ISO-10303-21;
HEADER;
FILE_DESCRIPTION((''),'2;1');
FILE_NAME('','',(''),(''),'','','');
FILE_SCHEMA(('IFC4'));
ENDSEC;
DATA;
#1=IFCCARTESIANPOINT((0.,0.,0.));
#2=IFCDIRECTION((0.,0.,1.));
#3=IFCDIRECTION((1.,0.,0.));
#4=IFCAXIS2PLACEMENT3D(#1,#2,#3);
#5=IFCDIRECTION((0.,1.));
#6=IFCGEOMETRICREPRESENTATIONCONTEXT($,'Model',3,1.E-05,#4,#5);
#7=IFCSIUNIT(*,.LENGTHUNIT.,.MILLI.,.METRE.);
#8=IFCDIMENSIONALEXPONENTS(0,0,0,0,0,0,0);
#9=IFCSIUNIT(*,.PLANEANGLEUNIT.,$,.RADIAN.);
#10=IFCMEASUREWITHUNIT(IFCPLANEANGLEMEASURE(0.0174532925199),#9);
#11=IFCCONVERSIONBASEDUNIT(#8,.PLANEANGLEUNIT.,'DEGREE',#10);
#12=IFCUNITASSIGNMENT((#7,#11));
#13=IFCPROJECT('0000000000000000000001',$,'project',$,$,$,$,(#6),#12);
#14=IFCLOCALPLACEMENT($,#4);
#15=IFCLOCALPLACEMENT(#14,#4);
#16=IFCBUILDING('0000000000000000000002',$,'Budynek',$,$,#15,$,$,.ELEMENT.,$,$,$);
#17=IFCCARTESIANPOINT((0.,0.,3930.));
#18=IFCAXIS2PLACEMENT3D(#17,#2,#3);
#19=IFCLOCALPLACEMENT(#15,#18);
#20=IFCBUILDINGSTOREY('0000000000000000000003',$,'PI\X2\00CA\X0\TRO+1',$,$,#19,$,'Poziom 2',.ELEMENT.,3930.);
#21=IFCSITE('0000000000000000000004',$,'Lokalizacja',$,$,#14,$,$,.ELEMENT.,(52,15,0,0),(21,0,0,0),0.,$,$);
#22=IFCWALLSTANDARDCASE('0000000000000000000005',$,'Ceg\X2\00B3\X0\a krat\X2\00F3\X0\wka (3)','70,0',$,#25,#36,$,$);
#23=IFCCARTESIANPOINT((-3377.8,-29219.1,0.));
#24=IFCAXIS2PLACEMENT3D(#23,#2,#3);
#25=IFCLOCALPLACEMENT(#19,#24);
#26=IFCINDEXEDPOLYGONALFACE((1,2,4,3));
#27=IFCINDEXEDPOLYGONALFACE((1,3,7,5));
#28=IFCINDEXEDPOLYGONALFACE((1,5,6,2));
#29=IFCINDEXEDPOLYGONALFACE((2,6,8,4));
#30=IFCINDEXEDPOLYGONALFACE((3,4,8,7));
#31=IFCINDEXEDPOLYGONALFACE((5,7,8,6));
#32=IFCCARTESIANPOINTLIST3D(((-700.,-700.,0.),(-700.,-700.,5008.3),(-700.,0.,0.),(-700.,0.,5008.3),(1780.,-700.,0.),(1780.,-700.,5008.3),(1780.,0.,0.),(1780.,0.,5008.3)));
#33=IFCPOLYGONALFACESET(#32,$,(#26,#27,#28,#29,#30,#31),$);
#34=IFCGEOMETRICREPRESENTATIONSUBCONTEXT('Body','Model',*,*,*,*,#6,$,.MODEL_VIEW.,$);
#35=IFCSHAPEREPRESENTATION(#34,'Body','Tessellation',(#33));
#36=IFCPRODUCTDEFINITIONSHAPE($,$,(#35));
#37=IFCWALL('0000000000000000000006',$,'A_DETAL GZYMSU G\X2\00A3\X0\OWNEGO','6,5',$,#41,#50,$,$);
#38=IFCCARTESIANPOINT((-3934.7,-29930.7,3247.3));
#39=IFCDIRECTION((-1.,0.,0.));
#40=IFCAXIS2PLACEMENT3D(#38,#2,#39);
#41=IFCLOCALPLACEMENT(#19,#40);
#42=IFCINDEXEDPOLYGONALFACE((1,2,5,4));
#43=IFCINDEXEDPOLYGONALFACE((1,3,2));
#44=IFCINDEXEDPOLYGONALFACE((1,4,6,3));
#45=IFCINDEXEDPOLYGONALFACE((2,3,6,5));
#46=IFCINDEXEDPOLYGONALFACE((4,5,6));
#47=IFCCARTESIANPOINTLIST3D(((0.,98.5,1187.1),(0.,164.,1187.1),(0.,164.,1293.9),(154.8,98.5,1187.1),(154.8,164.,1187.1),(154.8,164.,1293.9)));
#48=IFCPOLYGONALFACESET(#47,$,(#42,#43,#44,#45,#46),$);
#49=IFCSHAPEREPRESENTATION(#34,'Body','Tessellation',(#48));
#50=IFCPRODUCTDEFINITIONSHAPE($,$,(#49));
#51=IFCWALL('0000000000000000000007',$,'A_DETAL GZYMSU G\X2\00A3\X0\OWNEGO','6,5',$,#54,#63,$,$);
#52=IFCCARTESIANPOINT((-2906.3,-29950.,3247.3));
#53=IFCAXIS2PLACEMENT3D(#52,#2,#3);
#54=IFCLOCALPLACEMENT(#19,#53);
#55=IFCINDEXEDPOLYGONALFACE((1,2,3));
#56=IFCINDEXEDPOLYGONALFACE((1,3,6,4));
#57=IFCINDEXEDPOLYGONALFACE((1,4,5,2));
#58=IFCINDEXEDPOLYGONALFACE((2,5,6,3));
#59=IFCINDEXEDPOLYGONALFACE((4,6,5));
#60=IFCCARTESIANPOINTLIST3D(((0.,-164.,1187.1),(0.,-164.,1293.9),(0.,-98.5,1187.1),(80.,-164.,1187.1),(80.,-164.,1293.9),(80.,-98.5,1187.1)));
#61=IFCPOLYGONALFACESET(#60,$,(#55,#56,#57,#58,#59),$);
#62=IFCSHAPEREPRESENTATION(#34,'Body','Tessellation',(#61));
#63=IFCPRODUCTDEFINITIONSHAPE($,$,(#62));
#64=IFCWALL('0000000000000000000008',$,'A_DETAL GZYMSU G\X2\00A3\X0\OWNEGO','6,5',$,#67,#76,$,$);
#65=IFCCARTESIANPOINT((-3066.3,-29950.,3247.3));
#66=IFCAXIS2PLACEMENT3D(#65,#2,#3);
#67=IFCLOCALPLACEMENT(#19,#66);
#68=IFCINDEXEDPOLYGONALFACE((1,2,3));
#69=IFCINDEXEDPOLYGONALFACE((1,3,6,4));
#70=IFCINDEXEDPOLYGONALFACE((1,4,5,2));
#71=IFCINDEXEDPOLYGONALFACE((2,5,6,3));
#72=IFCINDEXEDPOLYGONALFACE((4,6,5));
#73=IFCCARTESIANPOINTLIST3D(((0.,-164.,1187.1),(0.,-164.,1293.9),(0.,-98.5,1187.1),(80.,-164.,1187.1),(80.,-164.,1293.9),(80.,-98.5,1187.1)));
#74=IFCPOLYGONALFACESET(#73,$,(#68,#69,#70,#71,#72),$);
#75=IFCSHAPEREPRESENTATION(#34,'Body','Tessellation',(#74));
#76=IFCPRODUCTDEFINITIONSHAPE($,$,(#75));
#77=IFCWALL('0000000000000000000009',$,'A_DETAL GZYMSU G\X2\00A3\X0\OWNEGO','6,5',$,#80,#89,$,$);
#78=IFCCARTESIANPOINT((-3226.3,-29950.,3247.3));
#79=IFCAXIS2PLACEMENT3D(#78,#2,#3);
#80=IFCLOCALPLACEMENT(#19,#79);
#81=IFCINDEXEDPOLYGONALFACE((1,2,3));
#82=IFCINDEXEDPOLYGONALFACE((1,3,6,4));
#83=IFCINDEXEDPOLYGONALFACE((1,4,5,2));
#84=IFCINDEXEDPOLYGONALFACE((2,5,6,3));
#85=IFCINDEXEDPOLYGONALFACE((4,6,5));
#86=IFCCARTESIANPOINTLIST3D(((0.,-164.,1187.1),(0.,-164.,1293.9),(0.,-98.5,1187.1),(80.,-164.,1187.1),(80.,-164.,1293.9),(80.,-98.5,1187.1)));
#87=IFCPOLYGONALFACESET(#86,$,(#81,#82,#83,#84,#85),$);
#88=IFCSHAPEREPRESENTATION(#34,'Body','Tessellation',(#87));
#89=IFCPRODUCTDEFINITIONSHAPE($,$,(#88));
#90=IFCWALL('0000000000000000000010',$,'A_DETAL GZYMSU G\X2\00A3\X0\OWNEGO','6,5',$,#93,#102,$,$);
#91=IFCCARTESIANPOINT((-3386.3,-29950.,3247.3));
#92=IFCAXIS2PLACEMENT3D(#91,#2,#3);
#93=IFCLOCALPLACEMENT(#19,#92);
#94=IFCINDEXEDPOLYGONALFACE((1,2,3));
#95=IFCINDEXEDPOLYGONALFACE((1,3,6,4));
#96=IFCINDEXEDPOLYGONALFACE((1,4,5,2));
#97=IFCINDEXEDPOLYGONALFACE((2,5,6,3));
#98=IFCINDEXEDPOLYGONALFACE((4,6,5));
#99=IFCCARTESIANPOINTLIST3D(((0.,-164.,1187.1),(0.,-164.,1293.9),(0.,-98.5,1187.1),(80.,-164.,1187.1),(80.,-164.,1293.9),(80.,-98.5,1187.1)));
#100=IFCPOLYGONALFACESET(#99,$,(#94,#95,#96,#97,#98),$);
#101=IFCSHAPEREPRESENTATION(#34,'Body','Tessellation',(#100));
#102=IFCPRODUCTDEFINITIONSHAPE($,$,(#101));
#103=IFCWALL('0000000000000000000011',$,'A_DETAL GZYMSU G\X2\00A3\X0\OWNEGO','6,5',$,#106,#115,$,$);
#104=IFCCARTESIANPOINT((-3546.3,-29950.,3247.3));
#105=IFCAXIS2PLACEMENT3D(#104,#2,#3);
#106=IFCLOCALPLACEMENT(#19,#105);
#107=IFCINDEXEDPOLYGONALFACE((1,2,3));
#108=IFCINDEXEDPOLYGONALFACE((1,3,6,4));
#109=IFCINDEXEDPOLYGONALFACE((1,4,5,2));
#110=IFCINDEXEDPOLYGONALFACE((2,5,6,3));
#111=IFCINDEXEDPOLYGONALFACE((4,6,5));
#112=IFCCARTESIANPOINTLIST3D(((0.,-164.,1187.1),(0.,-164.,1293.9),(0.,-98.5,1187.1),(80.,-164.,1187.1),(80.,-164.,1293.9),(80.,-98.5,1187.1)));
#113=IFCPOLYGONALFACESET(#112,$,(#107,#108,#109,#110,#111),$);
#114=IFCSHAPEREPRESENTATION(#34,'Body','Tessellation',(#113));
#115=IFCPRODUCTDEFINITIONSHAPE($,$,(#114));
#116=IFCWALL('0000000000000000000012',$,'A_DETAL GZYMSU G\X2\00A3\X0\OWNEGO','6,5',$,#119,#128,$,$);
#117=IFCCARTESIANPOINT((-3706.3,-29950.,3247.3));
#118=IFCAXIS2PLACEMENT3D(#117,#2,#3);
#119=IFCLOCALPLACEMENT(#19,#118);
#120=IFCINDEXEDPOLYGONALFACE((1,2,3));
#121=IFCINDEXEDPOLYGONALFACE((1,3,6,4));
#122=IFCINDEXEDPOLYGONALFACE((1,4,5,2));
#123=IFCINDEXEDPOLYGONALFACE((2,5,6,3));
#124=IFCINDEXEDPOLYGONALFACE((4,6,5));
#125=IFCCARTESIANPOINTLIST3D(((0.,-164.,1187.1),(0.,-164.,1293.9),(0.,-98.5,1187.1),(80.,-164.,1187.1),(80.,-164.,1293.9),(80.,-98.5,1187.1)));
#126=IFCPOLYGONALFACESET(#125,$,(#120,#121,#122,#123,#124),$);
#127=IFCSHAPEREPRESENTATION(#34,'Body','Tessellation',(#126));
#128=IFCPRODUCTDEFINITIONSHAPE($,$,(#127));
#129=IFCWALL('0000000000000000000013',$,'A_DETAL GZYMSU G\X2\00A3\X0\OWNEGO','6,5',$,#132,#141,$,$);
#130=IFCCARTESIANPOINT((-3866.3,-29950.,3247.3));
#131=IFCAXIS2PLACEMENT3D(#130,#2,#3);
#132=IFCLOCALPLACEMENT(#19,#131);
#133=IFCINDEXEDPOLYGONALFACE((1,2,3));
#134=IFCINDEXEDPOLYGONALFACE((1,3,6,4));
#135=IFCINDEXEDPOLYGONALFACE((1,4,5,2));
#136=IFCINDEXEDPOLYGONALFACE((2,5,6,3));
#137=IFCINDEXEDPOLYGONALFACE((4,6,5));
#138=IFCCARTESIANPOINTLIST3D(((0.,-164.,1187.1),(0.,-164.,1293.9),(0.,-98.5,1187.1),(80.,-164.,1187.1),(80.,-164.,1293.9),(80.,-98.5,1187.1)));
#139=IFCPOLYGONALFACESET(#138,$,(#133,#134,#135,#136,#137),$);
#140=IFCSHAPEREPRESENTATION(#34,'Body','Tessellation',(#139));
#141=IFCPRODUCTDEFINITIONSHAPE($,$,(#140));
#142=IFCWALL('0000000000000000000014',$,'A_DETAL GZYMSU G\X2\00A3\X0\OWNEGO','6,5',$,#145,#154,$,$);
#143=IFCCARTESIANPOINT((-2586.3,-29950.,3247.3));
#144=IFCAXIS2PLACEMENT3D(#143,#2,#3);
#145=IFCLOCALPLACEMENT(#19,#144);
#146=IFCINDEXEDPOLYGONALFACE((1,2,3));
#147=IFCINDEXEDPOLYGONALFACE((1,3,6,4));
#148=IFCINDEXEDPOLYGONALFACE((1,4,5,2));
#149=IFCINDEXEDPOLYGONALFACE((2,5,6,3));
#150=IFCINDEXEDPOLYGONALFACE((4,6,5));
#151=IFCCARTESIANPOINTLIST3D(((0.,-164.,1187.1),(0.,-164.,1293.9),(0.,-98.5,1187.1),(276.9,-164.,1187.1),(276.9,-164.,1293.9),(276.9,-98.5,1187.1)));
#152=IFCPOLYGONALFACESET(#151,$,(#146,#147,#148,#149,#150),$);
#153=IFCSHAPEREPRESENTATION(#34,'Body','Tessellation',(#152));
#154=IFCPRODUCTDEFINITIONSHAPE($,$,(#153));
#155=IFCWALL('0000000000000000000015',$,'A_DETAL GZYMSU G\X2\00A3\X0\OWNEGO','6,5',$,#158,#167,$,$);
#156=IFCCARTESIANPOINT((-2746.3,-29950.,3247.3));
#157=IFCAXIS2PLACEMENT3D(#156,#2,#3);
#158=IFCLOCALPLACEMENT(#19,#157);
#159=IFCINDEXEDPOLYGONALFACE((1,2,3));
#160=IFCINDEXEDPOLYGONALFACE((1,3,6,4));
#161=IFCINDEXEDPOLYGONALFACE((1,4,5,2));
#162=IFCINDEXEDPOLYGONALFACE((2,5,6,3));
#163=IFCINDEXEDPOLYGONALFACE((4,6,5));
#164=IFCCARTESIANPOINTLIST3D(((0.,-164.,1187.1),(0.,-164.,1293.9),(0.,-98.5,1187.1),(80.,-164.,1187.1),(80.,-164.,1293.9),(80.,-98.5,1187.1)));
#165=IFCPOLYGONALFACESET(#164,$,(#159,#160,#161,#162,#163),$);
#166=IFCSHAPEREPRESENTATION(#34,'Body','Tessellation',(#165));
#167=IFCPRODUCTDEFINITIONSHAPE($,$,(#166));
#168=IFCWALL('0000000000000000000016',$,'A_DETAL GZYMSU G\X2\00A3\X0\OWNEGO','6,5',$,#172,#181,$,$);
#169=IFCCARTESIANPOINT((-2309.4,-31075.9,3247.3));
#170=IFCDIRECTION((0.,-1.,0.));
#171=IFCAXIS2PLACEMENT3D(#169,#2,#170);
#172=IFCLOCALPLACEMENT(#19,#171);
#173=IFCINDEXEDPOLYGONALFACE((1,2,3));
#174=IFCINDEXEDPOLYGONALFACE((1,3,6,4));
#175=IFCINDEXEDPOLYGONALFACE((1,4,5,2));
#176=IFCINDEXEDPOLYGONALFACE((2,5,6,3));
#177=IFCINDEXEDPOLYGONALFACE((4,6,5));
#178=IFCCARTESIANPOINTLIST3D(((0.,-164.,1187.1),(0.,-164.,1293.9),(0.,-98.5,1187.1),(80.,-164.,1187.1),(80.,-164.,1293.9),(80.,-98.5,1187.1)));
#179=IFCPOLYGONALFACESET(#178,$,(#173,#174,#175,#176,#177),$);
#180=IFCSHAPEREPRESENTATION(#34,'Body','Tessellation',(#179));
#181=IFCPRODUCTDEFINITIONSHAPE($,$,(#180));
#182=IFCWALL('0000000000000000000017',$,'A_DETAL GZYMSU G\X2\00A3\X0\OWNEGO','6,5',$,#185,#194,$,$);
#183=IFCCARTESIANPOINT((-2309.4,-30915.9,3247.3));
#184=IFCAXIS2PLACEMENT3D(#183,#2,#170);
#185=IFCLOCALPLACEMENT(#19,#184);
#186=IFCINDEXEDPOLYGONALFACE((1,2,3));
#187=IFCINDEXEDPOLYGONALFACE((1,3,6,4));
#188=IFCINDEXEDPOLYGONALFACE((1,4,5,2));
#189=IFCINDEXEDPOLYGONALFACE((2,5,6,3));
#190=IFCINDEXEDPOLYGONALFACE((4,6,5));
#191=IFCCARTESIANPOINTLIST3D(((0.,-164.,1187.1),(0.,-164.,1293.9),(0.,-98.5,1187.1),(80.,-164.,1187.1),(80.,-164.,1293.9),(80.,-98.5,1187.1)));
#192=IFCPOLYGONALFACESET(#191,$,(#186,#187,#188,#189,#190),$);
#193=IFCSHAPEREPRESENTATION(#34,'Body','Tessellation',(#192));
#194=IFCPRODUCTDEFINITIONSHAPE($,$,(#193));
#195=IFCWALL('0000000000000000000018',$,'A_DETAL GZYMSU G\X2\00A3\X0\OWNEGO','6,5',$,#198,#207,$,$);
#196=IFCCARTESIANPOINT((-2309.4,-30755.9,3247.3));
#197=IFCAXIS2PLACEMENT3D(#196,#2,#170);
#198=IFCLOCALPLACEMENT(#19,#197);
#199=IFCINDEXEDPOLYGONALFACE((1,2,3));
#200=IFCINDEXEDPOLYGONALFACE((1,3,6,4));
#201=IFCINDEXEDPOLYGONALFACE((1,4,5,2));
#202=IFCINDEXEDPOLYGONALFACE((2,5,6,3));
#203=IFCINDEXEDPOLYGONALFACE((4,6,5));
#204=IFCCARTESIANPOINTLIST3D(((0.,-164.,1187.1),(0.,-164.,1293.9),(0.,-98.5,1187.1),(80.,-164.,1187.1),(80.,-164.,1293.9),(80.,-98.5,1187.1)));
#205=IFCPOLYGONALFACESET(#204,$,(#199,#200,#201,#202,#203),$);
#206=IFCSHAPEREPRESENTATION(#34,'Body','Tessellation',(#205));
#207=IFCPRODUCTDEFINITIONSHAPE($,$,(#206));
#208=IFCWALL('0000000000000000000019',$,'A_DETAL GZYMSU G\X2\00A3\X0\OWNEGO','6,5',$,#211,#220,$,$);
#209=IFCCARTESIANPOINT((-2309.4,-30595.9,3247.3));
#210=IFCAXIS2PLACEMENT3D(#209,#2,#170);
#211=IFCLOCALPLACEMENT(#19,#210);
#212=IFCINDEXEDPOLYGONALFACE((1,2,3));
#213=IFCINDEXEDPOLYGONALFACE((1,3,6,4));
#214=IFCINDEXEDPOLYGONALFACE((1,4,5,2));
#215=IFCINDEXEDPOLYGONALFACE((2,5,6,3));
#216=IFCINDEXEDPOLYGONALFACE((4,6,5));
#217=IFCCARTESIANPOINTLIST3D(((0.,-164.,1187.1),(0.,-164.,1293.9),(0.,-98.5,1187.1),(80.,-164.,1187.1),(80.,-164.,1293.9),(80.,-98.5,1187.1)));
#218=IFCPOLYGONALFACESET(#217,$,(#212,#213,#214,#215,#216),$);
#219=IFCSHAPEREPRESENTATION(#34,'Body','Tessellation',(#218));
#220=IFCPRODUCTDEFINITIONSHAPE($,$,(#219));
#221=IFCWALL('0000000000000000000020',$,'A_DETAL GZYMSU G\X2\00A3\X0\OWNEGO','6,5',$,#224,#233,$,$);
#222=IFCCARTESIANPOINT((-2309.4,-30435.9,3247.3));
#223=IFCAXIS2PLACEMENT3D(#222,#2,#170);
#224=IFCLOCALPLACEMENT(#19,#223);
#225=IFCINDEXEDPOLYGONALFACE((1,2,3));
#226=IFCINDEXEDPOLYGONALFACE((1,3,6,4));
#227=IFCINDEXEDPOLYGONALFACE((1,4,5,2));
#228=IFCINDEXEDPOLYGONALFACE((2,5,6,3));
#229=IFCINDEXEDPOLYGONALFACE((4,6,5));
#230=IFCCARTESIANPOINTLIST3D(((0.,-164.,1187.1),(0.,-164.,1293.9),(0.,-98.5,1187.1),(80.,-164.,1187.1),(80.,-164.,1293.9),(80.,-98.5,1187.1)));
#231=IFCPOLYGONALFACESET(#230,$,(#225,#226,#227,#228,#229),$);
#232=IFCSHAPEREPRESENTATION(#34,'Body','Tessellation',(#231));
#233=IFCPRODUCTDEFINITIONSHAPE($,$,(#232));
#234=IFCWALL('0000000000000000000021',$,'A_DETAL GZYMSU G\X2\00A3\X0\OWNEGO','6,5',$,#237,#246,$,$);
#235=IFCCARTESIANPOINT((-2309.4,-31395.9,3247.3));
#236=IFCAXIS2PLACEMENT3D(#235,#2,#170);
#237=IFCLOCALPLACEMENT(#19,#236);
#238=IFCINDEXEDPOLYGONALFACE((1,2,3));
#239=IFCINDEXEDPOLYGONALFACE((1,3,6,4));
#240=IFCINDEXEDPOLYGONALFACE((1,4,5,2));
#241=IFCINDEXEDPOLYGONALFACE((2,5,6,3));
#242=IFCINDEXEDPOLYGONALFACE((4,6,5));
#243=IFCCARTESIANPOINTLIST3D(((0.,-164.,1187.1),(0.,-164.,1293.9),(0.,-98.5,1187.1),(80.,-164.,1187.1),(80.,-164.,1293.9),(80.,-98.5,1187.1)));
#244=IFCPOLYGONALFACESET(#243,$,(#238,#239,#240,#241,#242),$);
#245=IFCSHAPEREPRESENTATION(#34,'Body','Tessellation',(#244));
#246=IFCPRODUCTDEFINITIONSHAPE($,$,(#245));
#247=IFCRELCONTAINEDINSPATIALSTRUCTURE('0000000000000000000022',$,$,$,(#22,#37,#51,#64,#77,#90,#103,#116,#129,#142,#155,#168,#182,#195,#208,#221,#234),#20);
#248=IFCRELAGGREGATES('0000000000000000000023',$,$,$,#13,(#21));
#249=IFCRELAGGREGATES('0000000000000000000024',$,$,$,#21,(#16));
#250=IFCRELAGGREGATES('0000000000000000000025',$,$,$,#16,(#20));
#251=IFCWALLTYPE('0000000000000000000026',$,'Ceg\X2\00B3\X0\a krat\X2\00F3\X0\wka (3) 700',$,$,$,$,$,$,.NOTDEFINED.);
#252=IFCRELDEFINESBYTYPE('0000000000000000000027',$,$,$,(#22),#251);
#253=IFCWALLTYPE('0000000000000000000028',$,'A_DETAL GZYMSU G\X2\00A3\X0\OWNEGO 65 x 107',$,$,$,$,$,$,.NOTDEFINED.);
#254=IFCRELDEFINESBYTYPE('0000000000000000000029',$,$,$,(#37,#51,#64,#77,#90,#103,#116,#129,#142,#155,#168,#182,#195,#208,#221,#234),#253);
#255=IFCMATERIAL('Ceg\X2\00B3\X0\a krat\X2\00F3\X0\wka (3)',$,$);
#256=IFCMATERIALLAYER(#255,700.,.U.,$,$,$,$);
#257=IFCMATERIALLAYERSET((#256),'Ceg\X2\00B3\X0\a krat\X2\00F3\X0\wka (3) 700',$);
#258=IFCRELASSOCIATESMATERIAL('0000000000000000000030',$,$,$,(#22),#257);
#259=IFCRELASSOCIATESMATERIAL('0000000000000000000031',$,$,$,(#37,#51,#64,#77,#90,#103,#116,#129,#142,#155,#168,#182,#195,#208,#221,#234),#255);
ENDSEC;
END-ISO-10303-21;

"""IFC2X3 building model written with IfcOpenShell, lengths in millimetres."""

from ifc_helpers import new_model, entity, si_unit, converted_unit, direction, frame, origin_with_axes, place, context, subcontext, project, spatial, polyline, outline, extrude, material, layer, layer_set, layer_usage, type_object, element, save


model = new_model("IFC2X3")

# Units and contexts
model_context = context("Model", 3, precision=1e-05, world=origin_with_axes(), true_north=direction((0.0, 1.0)))
body_context = subcontext(model_context, "Body", "Model", "MODEL_VIEW")
ifc_project = project(units=[si_unit("LENGTHUNIT", "METRE", prefix="MILLI"), converted_unit("PLANEANGLEUNIT", "DEGREE", entity("IfcPlaneAngleMeasure", 0.0174532925199), si_unit("PLANEANGLEUNIT", "RADIAN"), dimensions=[0, 0, 0, 0, 0, 0, 0])], contexts=[model_context])

# Site, building, storey
site_placement = place(None, origin_with_axes())
site = spatial("IfcSite", under=ifc_project, at=site_placement, Name="Lokalizacja", CompositionType="ELEMENT", RefLatitude=(52, 15, 0, 0), RefLongitude=(21, 0, 0, 0), RefElevation=0.0)
building_placement = place(site_placement, origin_with_axes())
building = spatial("IfcBuilding", under=site, at=building_placement, Name="Budynek", CompositionType="ELEMENT")
storey_placement = place(building_placement, frame((0.0, 0.0, 3930.0), z_axis=(0.0, 0.0, 1.0), x_axis=(1.0, 0.0, 0.0)))
storey = spatial("IfcBuildingStorey", under=building, at=storey_placement, Name="PIÊTRO+1", LongName="Poziom 2", CompositionType="ELEMENT", Elevation=3930.0)

# Walls
ifc_material = material(Name="Ceg³a kratówka (3)")
ifc_layer_1 = layer(ifc_material, 700.0, ventilated="UNKNOWN")
ifc_layer_set_1 = layer_set([ifc_layer_1], Name="Ceg³a kratówka (3) 700")
wall_type_1 = type_object("IfcWallType", Name="Ceg³a kratówka (3) 700", PredefinedType="NOTDEFINED")
ifc_layer_usage_1 = layer_usage(ifc_layer_set_1, "AXIS2", "NEGATIVE", 0.0)
wall_1_placement = place(storey_placement, frame((-3377.8, -29219.1, 0.0), z_axis=(0.0, 0.0, 1.0), x_axis=(1.0, 0.0, 0.0)))
element("IfcWallStandardCase", 1, at=wall_1_placement, inside=storey, type_object=wall_type_1, material=ifc_layer_usage_1, Name="Ceg³a kratówka (3)", Description="70,0", context=body_context, shape_type="SweptSolid", body=[
    extrude(outline(polyline([(-700.0, -700.0), (1780.0, -700.0), (1780.0, 0.0), (-700.0, 0.0), (-700.0, -700.0)])), origin_with_axes(), (0.0, 0.0, 1.0), 5008.3),
])
wall_type_2 = type_object("IfcWallType", Name="A_DETAL GZYMSU G£OWNEGO 65 x 107", PredefinedType="NOTDEFINED")
wall_2_placement = place(storey_placement, frame((-3934.7, -29930.7, 3247.3), z_axis=(0.0, 0.0, 1.0), x_axis=(-1.0, 0.0, 0.0)))
element("IfcWall", 2, at=wall_2_placement, inside=storey, type_object=wall_type_2, material=ifc_material, Name="A_DETAL GZYMSU G£OWNEGO", Description="6,5", context=body_context, shape_type="SweptSolid", body=[
    extrude(outline(polyline([(-164.0, 1293.9), (-164.0, 1187.1), (-98.5, 1187.1), (-164.0, 1293.9)])), frame((0.0, 0.0, 0.0), z_axis=(-1.0, 0.0, 0.0), x_axis=(0.0, -1.0, 0.0)), (0.0, 0.0, -1.0), 154.8),
])
for number, where, z_axis, x_axis, name in (
    (3, (-2906.3, -29950.0, 3247.3), (0.0, 0.0, 1.0), (1.0, 0.0, 0.0), "A_DETAL GZYMSU G£OWNEGO"),
    (4, (-3066.3, -29950.0, 3247.3), (0.0, 0.0, 1.0), (1.0, 0.0, 0.0), "A_DETAL GZYMSU G£OWNEGO"),
    (5, (-3226.3, -29950.0, 3247.3), (0.0, 0.0, 1.0), (1.0, 0.0, 0.0), "A_DETAL GZYMSU G£OWNEGO"),
    (6, (-3386.3, -29950.0, 3247.3), (0.0, 0.0, 1.0), (1.0, 0.0, 0.0), "A_DETAL GZYMSU G£OWNEGO"),
    (7, (-3546.3, -29950.0, 3247.3), (0.0, 0.0, 1.0), (1.0, 0.0, 0.0), "A_DETAL GZYMSU G£OWNEGO"),
    (8, (-3706.3, -29950.0, 3247.3), (0.0, 0.0, 1.0), (1.0, 0.0, 0.0), "A_DETAL GZYMSU G£OWNEGO"),
    (9, (-3866.3, -29950.0, 3247.3), (0.0, 0.0, 1.0), (1.0, 0.0, 0.0), "A_DETAL GZYMSU G£OWNEGO"),
):
    element("IfcWall", number, at=place(storey_placement, frame(where, z_axis=z_axis, x_axis=x_axis)), inside=storey, type_object=wall_type_2, material=ifc_material, Name=name, Description="6,5", context=body_context, shape_type="SweptSolid", body=[
        extrude(outline(polyline([(-164.0, 1293.9), (-164.0, 1187.1), (-98.5, 1187.1), (-164.0, 1293.9)])), frame((0.0, 0.0, 0.0), z_axis=(1.0, 0.0, 0.0), x_axis=(0.0, 1.0, 0.0)), (0.0, 0.0, 1.0), 80.0),
    ])
wall_3_placement = place(storey_placement, frame((-2586.3, -29950.0, 3247.3), z_axis=(0.0, 0.0, 1.0), x_axis=(1.0, 0.0, 0.0)))
element("IfcWall", 10, at=wall_3_placement, inside=storey, type_object=wall_type_2, material=ifc_material, Name="A_DETAL GZYMSU G£OWNEGO", Description="6,5", context=body_context, shape_type="SweptSolid", body=[
    extrude(outline(polyline([(-164.0, 1293.9), (-164.0, 1187.1), (-98.5, 1187.1), (-164.0, 1293.9)])), frame((0.0, 0.0, 0.0), z_axis=(1.0, 0.0, 0.0), x_axis=(0.0, 1.0, 0.0)), (0.0, 0.0, 1.0), 276.9),
])
for number, where, z_axis, x_axis, name in (
    (11, (-2746.3, -29950.0, 3247.3), (0.0, 0.0, 1.0), (1.0, 0.0, 0.0), "A_DETAL GZYMSU G£OWNEGO"),
    (12, (-2309.4, -31075.9, 3247.3), (0.0, 0.0, 1.0), (0.0, -1.0, 0.0), "A_DETAL GZYMSU G£OWNEGO"),
    (13, (-2309.4, -30915.9, 3247.3), (0.0, 0.0, 1.0), (0.0, -1.0, 0.0), "A_DETAL GZYMSU G£OWNEGO"),
    (14, (-2309.4, -30755.9, 3247.3), (0.0, 0.0, 1.0), (0.0, -1.0, 0.0), "A_DETAL GZYMSU G£OWNEGO"),
    (15, (-2309.4, -30595.9, 3247.3), (0.0, 0.0, 1.0), (0.0, -1.0, 0.0), "A_DETAL GZYMSU G£OWNEGO"),
    (16, (-2309.4, -30435.9, 3247.3), (0.0, 0.0, 1.0), (0.0, -1.0, 0.0), "A_DETAL GZYMSU G£OWNEGO"),
    (17, (-2309.4, -31395.9, 3247.3), (0.0, 0.0, 1.0), (0.0, -1.0, 0.0), "A_DETAL GZYMSU G£OWNEGO"),
):
    element("IfcWall", number, at=place(storey_placement, frame(where, z_axis=z_axis, x_axis=x_axis)), inside=storey, type_object=wall_type_2, material=ifc_material, Name=name, Description="6,5", context=body_context, shape_type="SweptSolid", body=[
        extrude(outline(polyline([(-164.0, 1293.9), (-164.0, 1187.1), (-98.5, 1187.1), (-164.0, 1293.9)])), frame((0.0, 0.0, 0.0), z_axis=(1.0, 0.0, 0.0), x_axis=(0.0, 1.0, 0.0)), (0.0, 0.0, 1.0), 80.0),
    ])

save(model, "model.ifc")
